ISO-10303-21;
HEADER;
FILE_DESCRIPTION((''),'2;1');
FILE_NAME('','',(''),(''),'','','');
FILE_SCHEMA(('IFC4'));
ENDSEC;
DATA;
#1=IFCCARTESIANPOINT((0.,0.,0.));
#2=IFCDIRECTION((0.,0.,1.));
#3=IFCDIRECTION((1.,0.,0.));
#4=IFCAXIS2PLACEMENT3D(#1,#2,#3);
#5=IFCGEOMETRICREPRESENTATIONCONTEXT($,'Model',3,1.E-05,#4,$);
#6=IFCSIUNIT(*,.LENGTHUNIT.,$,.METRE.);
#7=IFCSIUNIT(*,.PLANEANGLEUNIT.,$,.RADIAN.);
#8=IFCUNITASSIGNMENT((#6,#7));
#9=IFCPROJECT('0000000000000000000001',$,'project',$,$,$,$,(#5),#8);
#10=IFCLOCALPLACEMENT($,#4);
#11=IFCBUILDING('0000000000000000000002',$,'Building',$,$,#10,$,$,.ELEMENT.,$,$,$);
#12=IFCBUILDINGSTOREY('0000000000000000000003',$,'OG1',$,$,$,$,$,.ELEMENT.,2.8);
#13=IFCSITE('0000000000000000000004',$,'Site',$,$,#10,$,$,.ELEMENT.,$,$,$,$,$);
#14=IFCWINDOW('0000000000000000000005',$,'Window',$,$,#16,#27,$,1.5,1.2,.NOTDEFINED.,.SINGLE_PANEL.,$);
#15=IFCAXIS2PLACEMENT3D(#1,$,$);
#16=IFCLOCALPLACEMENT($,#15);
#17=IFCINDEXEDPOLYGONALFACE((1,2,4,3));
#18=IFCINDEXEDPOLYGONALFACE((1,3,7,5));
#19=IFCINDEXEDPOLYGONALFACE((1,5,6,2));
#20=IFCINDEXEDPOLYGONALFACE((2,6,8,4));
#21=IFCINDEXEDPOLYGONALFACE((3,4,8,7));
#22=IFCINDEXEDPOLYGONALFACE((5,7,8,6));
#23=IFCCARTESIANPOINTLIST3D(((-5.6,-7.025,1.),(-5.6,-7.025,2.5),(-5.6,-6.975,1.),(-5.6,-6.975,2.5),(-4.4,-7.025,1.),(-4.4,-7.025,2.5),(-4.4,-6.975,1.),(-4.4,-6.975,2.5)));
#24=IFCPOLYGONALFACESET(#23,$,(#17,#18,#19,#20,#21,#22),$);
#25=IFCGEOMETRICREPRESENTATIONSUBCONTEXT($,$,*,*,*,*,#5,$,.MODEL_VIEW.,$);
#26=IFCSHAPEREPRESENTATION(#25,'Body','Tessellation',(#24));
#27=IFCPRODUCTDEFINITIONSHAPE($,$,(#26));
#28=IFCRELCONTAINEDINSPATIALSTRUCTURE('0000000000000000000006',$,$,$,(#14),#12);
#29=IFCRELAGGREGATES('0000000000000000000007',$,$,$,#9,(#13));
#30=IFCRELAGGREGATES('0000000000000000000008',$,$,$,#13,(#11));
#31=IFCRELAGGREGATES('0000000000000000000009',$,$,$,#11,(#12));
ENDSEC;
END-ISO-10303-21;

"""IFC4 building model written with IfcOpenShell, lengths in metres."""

from ifc_helpers import new_model, si_unit, frame, origin, origin_with_axes, origin_2d, place, context, subcontext, project, spatial, rectangle, extrude, element, save


model = new_model("IFC4")

# Units and contexts
model_context = context("Model", 3, precision=1e-05, world=origin_with_axes())
sub_context = subcontext(model_context, None, None, "MODEL_VIEW")
ifc_project = project(units=[si_unit("LENGTHUNIT", "METRE"), si_unit("PLANEANGLEUNIT", "RADIAN")], contexts=[model_context])

# Site, building, storey
placement_1 = place(None, origin_with_axes())
site = spatial("IfcSite", under=ifc_project, at=placement_1, Name="Site", CompositionType="ELEMENT")
building = spatial("IfcBuilding", under=site, at=placement_1, Name="Building", CompositionType="ELEMENT")
storey = spatial("IfcBuildingStorey", under=building, Name="OG1", CompositionType="ELEMENT", Elevation=2.8)

# Window
placement_2 = place(None, origin_with_axes())
window_placement = place(placement_2, frame((-5.0, -7.0, 1.0)))
element("IfcWindow", 1, at=window_placement, inside=storey, Name="Window", OverallHeight=1.5, OverallWidth=1.2, PartitioningType="SINGLE_PANEL", PredefinedType="NOTDEFINED", context=sub_context, shape_type="SweptSolid", body=[
    extrude(rectangle(XDim=1.2, YDim=0.05, at=origin_2d()), origin(), (0.0, 0.0, 1.0), 1.5),
])

save(model, "model.ifc")
